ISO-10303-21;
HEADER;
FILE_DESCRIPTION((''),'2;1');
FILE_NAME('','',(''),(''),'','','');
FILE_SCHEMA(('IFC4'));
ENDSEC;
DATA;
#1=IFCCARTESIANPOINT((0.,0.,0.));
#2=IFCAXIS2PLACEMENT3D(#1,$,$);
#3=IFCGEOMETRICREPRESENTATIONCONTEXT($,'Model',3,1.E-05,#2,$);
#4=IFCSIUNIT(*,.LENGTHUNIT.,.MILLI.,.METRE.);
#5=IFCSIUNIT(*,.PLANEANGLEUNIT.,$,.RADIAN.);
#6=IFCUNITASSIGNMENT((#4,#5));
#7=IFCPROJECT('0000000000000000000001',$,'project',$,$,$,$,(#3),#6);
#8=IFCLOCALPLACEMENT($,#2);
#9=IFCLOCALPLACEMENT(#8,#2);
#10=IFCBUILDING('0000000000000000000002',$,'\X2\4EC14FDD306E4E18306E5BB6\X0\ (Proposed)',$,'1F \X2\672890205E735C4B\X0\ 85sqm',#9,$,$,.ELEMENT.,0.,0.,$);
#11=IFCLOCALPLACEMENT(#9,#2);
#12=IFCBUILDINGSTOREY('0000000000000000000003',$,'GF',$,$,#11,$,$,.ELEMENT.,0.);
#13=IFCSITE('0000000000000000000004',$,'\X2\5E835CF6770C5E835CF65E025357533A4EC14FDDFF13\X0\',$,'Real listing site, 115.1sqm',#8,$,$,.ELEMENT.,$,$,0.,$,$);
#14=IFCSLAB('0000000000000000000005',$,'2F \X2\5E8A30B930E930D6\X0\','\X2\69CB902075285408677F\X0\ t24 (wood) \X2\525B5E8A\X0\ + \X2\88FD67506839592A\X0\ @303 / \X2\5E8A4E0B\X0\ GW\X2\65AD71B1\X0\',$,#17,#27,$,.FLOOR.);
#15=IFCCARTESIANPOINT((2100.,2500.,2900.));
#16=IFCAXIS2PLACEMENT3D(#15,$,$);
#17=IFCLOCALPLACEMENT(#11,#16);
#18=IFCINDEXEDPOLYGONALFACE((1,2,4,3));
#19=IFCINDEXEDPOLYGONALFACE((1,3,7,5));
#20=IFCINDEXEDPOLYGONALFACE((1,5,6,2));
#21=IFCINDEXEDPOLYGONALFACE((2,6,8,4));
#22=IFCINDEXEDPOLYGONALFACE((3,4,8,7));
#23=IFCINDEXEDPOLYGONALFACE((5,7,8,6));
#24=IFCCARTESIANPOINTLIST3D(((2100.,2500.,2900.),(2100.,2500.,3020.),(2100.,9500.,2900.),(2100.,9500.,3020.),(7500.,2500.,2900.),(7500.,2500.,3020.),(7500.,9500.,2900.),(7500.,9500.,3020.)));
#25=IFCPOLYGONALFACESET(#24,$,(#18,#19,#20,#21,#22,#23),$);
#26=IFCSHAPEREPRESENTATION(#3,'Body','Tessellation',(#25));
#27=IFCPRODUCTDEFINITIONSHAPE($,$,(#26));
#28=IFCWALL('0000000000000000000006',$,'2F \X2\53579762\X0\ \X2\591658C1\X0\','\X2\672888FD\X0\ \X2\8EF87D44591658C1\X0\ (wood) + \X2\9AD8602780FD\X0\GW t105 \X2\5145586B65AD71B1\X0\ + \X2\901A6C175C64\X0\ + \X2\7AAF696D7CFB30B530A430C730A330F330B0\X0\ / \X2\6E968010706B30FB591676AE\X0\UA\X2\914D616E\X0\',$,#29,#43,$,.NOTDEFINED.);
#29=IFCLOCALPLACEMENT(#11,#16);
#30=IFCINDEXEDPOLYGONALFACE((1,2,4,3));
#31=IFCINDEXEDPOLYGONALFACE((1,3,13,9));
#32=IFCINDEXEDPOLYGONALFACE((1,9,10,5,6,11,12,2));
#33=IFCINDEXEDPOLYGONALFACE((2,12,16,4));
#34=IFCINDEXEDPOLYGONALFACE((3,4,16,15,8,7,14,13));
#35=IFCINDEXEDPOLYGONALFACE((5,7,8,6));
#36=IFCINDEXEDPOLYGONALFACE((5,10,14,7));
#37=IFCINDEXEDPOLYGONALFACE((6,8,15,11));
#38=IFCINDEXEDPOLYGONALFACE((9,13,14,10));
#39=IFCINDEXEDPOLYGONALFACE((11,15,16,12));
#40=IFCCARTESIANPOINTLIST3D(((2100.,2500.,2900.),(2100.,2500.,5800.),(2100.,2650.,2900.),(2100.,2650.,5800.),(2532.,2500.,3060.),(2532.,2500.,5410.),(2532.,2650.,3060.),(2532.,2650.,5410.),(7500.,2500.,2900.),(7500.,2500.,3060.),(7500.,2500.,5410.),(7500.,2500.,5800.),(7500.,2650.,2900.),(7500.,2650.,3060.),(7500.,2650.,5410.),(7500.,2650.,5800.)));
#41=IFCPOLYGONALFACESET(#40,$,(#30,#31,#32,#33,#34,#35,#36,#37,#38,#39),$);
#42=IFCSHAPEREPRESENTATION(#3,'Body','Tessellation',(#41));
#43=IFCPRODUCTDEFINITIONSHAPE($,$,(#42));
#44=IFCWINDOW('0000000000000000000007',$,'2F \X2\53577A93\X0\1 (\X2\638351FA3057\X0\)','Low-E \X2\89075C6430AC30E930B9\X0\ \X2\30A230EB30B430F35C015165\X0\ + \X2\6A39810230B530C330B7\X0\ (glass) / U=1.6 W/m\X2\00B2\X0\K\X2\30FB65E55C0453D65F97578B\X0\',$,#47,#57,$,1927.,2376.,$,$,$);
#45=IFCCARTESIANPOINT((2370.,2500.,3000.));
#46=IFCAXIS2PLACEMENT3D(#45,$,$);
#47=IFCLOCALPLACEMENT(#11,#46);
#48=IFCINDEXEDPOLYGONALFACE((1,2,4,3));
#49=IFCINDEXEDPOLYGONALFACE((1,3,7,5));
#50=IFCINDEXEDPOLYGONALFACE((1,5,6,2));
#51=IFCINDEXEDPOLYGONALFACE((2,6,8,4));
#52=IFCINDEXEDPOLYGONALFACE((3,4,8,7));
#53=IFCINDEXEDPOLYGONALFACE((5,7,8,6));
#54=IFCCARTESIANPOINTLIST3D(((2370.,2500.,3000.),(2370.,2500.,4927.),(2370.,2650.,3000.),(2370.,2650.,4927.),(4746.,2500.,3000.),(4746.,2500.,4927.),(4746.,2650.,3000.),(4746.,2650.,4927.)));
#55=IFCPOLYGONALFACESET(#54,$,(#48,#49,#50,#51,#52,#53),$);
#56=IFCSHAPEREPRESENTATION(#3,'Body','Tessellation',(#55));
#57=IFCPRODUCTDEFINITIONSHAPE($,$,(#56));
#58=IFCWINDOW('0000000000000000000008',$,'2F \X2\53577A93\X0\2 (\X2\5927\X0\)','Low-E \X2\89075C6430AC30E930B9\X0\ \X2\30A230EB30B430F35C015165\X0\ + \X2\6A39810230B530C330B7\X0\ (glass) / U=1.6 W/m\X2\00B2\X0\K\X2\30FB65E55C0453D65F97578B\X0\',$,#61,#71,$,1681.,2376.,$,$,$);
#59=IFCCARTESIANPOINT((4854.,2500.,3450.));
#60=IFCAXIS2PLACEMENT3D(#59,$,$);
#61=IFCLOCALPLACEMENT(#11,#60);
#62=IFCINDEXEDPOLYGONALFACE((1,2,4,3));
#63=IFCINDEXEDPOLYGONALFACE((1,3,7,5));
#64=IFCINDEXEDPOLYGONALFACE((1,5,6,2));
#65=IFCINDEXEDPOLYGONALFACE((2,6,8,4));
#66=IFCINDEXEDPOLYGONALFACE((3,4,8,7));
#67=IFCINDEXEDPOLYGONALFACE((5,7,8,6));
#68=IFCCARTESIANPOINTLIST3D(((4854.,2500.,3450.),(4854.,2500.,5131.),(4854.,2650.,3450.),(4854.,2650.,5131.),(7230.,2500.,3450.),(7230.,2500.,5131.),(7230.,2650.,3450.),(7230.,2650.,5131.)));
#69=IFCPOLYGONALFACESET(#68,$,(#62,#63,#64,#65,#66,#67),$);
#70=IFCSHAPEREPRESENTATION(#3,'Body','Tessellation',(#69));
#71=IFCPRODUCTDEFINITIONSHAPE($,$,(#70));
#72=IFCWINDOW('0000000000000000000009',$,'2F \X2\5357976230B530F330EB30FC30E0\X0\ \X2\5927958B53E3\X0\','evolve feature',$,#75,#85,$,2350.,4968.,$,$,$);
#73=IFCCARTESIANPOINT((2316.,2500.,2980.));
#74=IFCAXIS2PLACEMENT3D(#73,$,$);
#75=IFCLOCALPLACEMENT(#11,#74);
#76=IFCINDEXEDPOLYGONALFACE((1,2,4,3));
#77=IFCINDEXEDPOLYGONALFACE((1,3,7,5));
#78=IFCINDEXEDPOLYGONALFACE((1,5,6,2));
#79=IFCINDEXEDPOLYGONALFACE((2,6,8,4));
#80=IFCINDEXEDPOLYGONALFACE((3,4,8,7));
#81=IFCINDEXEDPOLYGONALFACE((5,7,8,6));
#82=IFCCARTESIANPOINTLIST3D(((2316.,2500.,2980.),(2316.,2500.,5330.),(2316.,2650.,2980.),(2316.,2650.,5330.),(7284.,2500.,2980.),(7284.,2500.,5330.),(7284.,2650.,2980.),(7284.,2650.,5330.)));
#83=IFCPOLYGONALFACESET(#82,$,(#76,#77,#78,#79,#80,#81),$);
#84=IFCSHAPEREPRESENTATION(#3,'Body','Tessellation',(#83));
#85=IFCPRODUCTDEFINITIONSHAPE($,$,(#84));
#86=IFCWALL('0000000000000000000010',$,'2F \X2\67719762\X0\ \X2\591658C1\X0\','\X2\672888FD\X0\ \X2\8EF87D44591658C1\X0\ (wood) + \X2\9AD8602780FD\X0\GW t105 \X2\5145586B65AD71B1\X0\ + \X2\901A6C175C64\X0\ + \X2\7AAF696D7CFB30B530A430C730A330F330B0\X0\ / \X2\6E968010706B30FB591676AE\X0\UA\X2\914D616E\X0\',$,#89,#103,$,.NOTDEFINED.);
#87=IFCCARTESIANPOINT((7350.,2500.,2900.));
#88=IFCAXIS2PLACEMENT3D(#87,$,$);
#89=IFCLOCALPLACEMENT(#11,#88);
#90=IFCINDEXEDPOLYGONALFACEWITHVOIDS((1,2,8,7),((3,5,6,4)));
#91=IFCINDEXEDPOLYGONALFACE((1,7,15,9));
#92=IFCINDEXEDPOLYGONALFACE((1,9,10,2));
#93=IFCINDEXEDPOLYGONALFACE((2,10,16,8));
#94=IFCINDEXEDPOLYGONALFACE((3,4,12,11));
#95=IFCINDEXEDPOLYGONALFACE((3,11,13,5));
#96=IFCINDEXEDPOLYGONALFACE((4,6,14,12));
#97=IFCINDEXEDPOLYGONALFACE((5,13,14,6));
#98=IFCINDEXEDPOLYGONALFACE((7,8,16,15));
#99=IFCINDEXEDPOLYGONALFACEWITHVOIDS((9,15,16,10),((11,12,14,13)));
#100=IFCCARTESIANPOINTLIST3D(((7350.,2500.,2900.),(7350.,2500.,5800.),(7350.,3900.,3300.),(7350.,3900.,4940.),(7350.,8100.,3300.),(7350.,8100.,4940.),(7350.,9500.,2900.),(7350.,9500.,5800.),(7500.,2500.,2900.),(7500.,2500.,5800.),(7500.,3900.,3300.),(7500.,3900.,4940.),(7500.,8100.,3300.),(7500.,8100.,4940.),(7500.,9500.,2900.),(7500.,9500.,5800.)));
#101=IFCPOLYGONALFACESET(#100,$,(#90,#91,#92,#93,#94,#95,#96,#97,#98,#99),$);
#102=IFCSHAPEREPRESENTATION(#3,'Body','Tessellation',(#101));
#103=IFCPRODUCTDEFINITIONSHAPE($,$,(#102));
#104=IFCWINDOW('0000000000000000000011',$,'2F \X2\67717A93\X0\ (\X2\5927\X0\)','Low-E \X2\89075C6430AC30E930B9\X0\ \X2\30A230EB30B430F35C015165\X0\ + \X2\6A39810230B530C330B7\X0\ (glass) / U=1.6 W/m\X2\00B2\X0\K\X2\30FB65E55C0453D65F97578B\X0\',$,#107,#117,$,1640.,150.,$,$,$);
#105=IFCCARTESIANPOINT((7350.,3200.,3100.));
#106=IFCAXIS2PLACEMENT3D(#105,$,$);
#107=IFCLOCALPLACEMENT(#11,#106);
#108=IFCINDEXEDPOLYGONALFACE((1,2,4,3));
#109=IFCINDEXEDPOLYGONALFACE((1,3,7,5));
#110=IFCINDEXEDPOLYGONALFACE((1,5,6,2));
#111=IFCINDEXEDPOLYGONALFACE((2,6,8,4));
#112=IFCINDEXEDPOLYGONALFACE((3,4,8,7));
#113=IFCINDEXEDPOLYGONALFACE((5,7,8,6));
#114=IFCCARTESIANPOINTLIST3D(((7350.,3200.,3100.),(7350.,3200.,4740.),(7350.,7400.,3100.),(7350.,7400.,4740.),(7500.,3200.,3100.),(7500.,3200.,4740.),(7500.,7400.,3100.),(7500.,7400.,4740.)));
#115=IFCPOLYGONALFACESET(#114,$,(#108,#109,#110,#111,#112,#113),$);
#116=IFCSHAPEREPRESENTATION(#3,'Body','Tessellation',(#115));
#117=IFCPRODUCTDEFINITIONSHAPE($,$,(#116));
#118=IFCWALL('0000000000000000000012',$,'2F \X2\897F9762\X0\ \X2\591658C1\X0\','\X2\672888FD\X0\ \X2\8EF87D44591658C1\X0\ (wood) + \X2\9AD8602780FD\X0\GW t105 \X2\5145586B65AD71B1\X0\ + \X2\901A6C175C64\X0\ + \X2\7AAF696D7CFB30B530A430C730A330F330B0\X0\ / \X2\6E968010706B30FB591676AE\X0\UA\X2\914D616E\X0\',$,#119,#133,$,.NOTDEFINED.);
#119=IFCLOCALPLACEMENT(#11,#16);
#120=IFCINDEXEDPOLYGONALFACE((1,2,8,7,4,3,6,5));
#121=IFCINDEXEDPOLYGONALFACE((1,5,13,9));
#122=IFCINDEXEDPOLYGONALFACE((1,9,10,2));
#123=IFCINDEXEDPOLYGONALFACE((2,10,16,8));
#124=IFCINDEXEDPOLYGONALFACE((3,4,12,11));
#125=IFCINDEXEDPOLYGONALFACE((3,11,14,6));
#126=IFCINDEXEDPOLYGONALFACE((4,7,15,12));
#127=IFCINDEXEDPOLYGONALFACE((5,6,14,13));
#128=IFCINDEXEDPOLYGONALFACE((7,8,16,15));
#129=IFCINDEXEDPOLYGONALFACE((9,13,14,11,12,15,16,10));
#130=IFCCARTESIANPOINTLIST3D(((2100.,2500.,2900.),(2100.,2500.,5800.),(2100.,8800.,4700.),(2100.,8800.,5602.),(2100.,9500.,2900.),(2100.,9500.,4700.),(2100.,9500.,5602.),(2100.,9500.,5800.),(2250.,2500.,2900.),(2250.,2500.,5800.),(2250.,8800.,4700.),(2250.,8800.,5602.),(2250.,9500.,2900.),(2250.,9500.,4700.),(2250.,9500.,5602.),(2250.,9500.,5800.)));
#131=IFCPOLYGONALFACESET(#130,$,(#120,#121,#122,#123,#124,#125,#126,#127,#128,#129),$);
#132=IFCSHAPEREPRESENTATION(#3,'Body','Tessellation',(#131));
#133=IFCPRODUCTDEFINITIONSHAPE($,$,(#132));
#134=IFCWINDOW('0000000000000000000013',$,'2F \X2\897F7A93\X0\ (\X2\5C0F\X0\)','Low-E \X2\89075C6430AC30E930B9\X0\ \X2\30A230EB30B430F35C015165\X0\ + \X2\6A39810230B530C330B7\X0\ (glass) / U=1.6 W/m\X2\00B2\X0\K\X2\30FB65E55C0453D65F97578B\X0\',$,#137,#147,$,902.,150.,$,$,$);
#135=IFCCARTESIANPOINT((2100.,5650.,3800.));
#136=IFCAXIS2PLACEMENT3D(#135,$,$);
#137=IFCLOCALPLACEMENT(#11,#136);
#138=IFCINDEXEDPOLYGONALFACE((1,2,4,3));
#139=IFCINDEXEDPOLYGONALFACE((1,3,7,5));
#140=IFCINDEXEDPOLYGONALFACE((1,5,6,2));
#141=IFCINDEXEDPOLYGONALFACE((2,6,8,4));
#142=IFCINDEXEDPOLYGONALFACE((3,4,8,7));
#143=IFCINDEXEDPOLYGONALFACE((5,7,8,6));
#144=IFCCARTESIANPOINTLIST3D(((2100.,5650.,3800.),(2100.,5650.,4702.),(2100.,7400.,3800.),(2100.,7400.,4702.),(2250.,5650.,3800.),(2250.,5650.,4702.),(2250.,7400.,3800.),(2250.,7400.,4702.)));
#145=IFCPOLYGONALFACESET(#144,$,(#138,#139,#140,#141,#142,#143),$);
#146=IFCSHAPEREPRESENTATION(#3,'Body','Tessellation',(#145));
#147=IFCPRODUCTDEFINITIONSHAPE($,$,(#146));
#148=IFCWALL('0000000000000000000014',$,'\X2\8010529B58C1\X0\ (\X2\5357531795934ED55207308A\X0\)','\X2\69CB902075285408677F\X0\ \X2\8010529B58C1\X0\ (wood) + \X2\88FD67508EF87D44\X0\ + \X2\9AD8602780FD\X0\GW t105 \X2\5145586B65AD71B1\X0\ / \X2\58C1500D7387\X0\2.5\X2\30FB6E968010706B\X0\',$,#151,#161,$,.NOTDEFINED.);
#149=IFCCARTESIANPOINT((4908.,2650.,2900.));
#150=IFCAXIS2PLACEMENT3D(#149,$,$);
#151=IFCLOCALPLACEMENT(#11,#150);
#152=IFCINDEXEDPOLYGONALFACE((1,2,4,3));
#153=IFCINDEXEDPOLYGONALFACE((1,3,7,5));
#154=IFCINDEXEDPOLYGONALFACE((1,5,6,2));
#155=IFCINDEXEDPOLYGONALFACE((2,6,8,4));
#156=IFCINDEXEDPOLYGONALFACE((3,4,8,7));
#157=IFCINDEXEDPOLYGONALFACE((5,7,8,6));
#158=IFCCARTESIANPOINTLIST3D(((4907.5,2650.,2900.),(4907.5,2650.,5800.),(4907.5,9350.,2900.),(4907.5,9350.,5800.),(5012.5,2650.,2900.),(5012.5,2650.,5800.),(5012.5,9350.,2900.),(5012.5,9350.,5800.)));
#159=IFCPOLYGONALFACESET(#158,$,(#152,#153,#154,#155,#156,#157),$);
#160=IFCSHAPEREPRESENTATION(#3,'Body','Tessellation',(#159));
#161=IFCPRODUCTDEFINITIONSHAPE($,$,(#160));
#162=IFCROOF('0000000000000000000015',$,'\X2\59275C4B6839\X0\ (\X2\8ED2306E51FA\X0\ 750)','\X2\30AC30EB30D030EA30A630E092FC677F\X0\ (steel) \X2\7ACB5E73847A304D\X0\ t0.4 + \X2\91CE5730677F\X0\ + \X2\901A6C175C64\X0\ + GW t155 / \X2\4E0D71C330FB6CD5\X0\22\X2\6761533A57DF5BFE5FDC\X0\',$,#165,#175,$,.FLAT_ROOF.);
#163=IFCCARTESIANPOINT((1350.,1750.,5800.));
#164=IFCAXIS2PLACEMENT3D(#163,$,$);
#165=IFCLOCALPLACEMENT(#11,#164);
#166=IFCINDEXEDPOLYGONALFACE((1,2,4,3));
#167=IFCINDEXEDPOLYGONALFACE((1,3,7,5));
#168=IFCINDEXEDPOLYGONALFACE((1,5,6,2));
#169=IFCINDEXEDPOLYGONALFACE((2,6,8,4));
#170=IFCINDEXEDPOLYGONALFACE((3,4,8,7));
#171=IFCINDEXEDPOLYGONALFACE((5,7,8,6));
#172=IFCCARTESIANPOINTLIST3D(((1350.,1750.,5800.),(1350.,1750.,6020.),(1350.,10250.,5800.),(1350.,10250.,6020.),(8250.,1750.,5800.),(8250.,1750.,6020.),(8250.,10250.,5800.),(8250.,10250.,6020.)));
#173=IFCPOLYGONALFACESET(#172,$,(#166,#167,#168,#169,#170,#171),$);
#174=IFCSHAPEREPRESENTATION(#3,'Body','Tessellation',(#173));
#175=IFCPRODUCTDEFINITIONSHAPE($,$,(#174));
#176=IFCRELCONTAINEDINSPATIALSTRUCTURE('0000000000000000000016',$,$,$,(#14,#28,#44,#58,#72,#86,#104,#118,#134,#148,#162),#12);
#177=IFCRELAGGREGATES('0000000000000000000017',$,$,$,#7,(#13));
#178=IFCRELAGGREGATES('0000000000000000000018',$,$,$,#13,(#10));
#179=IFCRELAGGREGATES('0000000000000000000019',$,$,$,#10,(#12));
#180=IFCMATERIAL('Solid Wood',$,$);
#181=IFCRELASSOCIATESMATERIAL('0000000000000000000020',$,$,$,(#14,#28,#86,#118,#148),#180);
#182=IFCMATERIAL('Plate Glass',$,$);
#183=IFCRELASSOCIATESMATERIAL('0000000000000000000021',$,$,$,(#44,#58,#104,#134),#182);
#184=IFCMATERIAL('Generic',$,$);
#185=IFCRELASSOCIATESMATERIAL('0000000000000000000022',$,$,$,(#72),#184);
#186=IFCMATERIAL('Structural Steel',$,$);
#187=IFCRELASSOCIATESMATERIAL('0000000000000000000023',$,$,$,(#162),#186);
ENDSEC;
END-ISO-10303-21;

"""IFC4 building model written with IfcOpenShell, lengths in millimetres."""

from ifc_helpers import new_model, si_unit, frame, frame_2d, origin, place, context, project, spatial, rectangle, extrude, material, element, fill, save


model = new_model("IFC4")

# Units and contexts
model_context = context("Model", 3, precision=1e-05, world=origin())
ifc_project = project(units=[si_unit("LENGTHUNIT", "METRE", prefix="MILLI"), si_unit("PLANEANGLEUNIT", "RADIAN")], contexts=[model_context])

# Site, building, storey
site_placement = place(None, origin())
site = spatial("IfcSite", under=ifc_project, at=site_placement, Name="広島県広島市南区仁保３", ObjectType="Real listing site, 115.1sqm", CompositionType="ELEMENT", RefElevation=0.0)
building_placement = place(site_placement, origin())
building = spatial("IfcBuilding", under=site, at=building_placement, Name="仁保の丘の家 (Proposed)", ObjectType="1F 木造平屋 85sqm", CompositionType="ELEMENT", ElevationOfRefHeight=0.0, ElevationOfTerrain=0.0)
storey_placement = place(building_placement, origin())
storey = spatial("IfcBuildingStorey", under=building, at=storey_placement, Name="GF", CompositionType="ELEMENT", Elevation=0.0)

# Slab
ifc_material_1 = material(Name="Solid Wood")
slab_placement = place(storey_placement, frame((2100.0, 2500.0, 2900.0)))
element("IfcSlab", 1, at=slab_placement, inside=storey, material=ifc_material_1, Name="2F 床スラブ", Description="構造用合板 t24 (wood) 剛床 + 製材根太 @303 / 床下 GW断熱", PredefinedType="FLOOR", context=model_context, shape_type="SweptSolid", body=[
    extrude(rectangle(XDim=5400.0, YDim=7000.0, at=frame_2d((2700.0, 3500.0))), frame((2100.0, 2500.0, 2900.0)), (0.0, 0.0, 1.0), 120.0),
])

# Wall, openings, windows
wall_1_placement = place(storey_placement, frame((2100.0, 2500.0, 2900.0)))
wall_1 = element("IfcWall", 2, at=wall_1_placement, inside=storey, material=ifc_material_1, Name="2F 南面 外壁", Description="木製 軸組外壁 (wood) + 高性能GW t105 充填断熱 + 通気層 + 窯業系サイディング / 準耐火・外皮UA配慮", PredefinedType="NOTDEFINED", context=model_context, shape_type="SweptSolid", body=[
    extrude(rectangle(XDim=5400.0, YDim=150.0, at=frame_2d((2700.0, 75.0))), frame((2100.0, 2500.0, 2900.0)), (0.0, 0.0, 1.0), 2900.0),
])
opening_1_placement = place(storey_placement, frame((2370.0, 2500.0, 3000.0)))
opening_1 = element("IfcOpeningElement", 3, at=opening_1_placement, cuts=wall_1, PredefinedType="NOTDEFINED", context=model_context, shape_type="SweptSolid", body=[
    extrude(rectangle(XDim=2376.0, YDim=150.0, at=frame_2d((1188.0, 75.0))), frame((2370.0, 2500.0, 3000.0)), (0.0, 0.0, 1.0), 1927.0),
])
opening_2_placement = place(storey_placement, frame((4854.0, 2500.0, 3450.0)))
opening_2 = element("IfcOpeningElement", 4, at=opening_2_placement, cuts=wall_1, PredefinedType="NOTDEFINED", context=model_context, shape_type="SweptSolid", body=[
    extrude(rectangle(XDim=2376.0, YDim=150.0, at=frame_2d((1188.0, 75.0))), frame((4854.0, 2500.0, 3450.0)), (0.0, 0.0, 1.0), 1681.0),
])
opening_3_placement = place(storey_placement, frame((2316.0, 2500.0, 2980.0)))
opening_3 = element("IfcOpeningElement", 5, at=opening_3_placement, cuts=wall_1, PredefinedType="NOTDEFINED", context=model_context, shape_type="SweptSolid", body=[
    extrude(rectangle(XDim=4968.0, YDim=150.0, at=frame_2d((2484.0, 75.0))), frame((2316.0, 2500.0, 2980.0)), (0.0, 0.0, 1.0), 2350.0),
])
ifc_material_2 = material(Name="Plate Glass")
window_1_placement = place(storey_placement, frame((2370.0, 2500.0, 3000.0)))
window_1 = element("IfcWindow", 6, at=window_1_placement, inside=storey, material=ifc_material_2, Name="2F 南窓1 (掃出し)", Description="Low-E 複層ガラス アルゴン封入 + 樹脂サッシ (glass) / U=1.6 W/m²K・日射取得型", OverallHeight=1927.0, OverallWidth=2376.0, context=model_context, shape_type="SweptSolid", body=[
    extrude(rectangle(XDim=2376.0, YDim=150.0, at=frame_2d((1188.0, 75.0))), frame((2370.0, 2500.0, 3000.0)), (0.0, 0.0, 1.0), 1927.0),
])
fill(opening_1, window_1)
window_2_placement = place(storey_placement, frame((4854.0, 2500.0, 3450.0)))
window_2 = element("IfcWindow", 7, at=window_2_placement, inside=storey, material=ifc_material_2, Name="2F 南窓2 (大)", Description="Low-E 複層ガラス アルゴン封入 + 樹脂サッシ (glass) / U=1.6 W/m²K・日射取得型", OverallHeight=1681.0, OverallWidth=2376.0, context=model_context, shape_type="SweptSolid", body=[
    extrude(rectangle(XDim=2376.0, YDim=150.0, at=frame_2d((1188.0, 75.0))), frame((4854.0, 2500.0, 3450.0)), (0.0, 0.0, 1.0), 1681.0),
])
fill(opening_2, window_2)
ifc_material_3 = material(Name="Generic")
window_3_placement = place(storey_placement, frame((2316.0, 2500.0, 2980.0)))
window_3 = element("IfcWindow", 8, at=window_3_placement, inside=storey, material=ifc_material_3, Name="2F 南面サンルーム 大開口", Description="evolve feature", OverallHeight=2350.0, OverallWidth=4968.0, context=model_context, shape_type="SweptSolid", body=[
    extrude(rectangle(XDim=4968.0, YDim=150.0, at=frame_2d((2484.0, 75.0))), frame((2316.0, 2500.0, 2980.0)), (0.0, 0.0, 1.0), 2350.0),
])
fill(opening_3, window_3)

# Walls, openings, windows
wall_2_placement = place(storey_placement, frame((7350.0, 2500.0, 2900.0)))
wall_2 = element("IfcWall", 9, at=wall_2_placement, inside=storey, material=ifc_material_1, Name="2F 東面 外壁", Description="木製 軸組外壁 (wood) + 高性能GW t105 充填断熱 + 通気層 + 窯業系サイディング / 準耐火・外皮UA配慮", PredefinedType="NOTDEFINED", context=model_context, shape_type="SweptSolid", body=[
    extrude(rectangle(XDim=150.0, YDim=7000.0, at=frame_2d((75.0, 3500.0))), frame((7350.0, 2500.0, 2900.0)), (0.0, 0.0, 1.0), 2900.0),
])
opening_4_placement = place(storey_placement, frame((7350.0, 3200.0, 3100.0)))
opening_4 = element("IfcOpeningElement", 10, at=opening_4_placement, cuts=wall_2, PredefinedType="NOTDEFINED", context=model_context, shape_type="SweptSolid", body=[
    extrude(rectangle(XDim=150.0, YDim=4200.0, at=frame_2d((75.0, 2100.0))), frame((7350.0, 3200.0, 3100.0)), (0.0, 0.0, 1.0), 1640.0),
])
window_4_placement = place(storey_placement, frame((7350.0, 3200.0, 3100.0)))
window_4 = element("IfcWindow", 11, at=window_4_placement, inside=storey, material=ifc_material_2, Name="2F 東窓 (大)", Description="Low-E 複層ガラス アルゴン封入 + 樹脂サッシ (glass) / U=1.6 W/m²K・日射取得型", OverallHeight=1640.0, OverallWidth=150.0, context=model_context, shape_type="SweptSolid", body=[
    extrude(rectangle(XDim=150.0, YDim=4200.0, at=frame_2d((75.0, 2100.0))), frame((7350.0, 3200.0, 3100.0)), (0.0, 0.0, 1.0), 1640.0),
])
fill(opening_4, window_4)
wall_3_placement = place(storey_placement, frame((2100.0, 2500.0, 2900.0)))
wall_3 = element("IfcWall", 12, at=wall_3_placement, inside=storey, material=ifc_material_1, Name="2F 西面 外壁", Description="木製 軸組外壁 (wood) + 高性能GW t105 充填断熱 + 通気層 + 窯業系サイディング / 準耐火・外皮UA配慮", PredefinedType="NOTDEFINED", context=model_context, shape_type="SweptSolid", body=[
    extrude(rectangle(XDim=150.0, YDim=7000.0, at=frame_2d((75.0, 3500.0))), frame((2100.0, 2500.0, 2900.0)), (0.0, 0.0, 1.0), 2900.0),
])
opening_5_placement = place(storey_placement, frame((2100.0, 5650.0, 3800.0)))
opening_5 = element("IfcOpeningElement", 13, at=opening_5_placement, cuts=wall_3, PredefinedType="NOTDEFINED", context=model_context, shape_type="SweptSolid", body=[
    extrude(rectangle(XDim=150.0, YDim=1750.0, at=frame_2d((75.0, 875.0))), frame((2100.0, 5650.0, 3800.0)), (0.0, 0.0, 1.0), 902.0),
])
window_5_placement = place(storey_placement, frame((2100.0, 5650.0, 3800.0)))
window_5 = element("IfcWindow", 14, at=window_5_placement, inside=storey, material=ifc_material_2, Name="2F 西窓 (小)", Description="Low-E 複層ガラス アルゴン封入 + 樹脂サッシ (glass) / U=1.6 W/m²K・日射取得型", OverallHeight=902.0, OverallWidth=150.0, context=model_context, shape_type="SweptSolid", body=[
    extrude(rectangle(XDim=150.0, YDim=1750.0, at=frame_2d((75.0, 875.0))), frame((2100.0, 5650.0, 3800.0)), (0.0, 0.0, 1.0), 902.0),
])
fill(opening_5, window_5)

# Wall
wall_4_placement = place(storey_placement, frame((4908.0, 2650.0, 2900.0)))
element("IfcWall", 15, at=wall_4_placement, inside=storey, material=ifc_material_1, Name="耐力壁 (南北間仕切り)", Description="構造用合板 耐力壁 (wood) + 製材軸組 + 高性能GW t105 充填断熱 / 壁倍率2.5・準耐火", PredefinedType="NOTDEFINED", context=model_context, shape_type="SweptSolid", body=[
    extrude(rectangle(XDim=105.0, YDim=6700.0, at=frame_2d((52.0, 3350.0))), frame((4908.0, 2650.0, 2900.0)), (0.0, 0.0, 1.0), 2900.0),
])

# Roof
ifc_material_4 = material(Name="Structural Steel")
roof_placement = place(storey_placement, frame((1350.0, 1750.0, 5800.0)))
element("IfcRoof", 16, at=roof_placement, inside=storey, material=ifc_material_4, Name="大屋根 (軒の出 750)", Description="ガルバリウム鋼板 (steel) 立平葺き t0.4 + 野地板 + 通気層 + GW t155 / 不燃・法22条区域対応", PredefinedType="FLAT_ROOF", context=model_context, shape_type="SweptSolid", body=[
    extrude(rectangle(XDim=6900.0, YDim=8500.0, at=frame_2d((3450.0, 4250.0))), frame((1350.0, 1750.0, 5800.0)), (0.0, 0.0, 1.0), 220.0),
])

save(model, "model.ifc")
